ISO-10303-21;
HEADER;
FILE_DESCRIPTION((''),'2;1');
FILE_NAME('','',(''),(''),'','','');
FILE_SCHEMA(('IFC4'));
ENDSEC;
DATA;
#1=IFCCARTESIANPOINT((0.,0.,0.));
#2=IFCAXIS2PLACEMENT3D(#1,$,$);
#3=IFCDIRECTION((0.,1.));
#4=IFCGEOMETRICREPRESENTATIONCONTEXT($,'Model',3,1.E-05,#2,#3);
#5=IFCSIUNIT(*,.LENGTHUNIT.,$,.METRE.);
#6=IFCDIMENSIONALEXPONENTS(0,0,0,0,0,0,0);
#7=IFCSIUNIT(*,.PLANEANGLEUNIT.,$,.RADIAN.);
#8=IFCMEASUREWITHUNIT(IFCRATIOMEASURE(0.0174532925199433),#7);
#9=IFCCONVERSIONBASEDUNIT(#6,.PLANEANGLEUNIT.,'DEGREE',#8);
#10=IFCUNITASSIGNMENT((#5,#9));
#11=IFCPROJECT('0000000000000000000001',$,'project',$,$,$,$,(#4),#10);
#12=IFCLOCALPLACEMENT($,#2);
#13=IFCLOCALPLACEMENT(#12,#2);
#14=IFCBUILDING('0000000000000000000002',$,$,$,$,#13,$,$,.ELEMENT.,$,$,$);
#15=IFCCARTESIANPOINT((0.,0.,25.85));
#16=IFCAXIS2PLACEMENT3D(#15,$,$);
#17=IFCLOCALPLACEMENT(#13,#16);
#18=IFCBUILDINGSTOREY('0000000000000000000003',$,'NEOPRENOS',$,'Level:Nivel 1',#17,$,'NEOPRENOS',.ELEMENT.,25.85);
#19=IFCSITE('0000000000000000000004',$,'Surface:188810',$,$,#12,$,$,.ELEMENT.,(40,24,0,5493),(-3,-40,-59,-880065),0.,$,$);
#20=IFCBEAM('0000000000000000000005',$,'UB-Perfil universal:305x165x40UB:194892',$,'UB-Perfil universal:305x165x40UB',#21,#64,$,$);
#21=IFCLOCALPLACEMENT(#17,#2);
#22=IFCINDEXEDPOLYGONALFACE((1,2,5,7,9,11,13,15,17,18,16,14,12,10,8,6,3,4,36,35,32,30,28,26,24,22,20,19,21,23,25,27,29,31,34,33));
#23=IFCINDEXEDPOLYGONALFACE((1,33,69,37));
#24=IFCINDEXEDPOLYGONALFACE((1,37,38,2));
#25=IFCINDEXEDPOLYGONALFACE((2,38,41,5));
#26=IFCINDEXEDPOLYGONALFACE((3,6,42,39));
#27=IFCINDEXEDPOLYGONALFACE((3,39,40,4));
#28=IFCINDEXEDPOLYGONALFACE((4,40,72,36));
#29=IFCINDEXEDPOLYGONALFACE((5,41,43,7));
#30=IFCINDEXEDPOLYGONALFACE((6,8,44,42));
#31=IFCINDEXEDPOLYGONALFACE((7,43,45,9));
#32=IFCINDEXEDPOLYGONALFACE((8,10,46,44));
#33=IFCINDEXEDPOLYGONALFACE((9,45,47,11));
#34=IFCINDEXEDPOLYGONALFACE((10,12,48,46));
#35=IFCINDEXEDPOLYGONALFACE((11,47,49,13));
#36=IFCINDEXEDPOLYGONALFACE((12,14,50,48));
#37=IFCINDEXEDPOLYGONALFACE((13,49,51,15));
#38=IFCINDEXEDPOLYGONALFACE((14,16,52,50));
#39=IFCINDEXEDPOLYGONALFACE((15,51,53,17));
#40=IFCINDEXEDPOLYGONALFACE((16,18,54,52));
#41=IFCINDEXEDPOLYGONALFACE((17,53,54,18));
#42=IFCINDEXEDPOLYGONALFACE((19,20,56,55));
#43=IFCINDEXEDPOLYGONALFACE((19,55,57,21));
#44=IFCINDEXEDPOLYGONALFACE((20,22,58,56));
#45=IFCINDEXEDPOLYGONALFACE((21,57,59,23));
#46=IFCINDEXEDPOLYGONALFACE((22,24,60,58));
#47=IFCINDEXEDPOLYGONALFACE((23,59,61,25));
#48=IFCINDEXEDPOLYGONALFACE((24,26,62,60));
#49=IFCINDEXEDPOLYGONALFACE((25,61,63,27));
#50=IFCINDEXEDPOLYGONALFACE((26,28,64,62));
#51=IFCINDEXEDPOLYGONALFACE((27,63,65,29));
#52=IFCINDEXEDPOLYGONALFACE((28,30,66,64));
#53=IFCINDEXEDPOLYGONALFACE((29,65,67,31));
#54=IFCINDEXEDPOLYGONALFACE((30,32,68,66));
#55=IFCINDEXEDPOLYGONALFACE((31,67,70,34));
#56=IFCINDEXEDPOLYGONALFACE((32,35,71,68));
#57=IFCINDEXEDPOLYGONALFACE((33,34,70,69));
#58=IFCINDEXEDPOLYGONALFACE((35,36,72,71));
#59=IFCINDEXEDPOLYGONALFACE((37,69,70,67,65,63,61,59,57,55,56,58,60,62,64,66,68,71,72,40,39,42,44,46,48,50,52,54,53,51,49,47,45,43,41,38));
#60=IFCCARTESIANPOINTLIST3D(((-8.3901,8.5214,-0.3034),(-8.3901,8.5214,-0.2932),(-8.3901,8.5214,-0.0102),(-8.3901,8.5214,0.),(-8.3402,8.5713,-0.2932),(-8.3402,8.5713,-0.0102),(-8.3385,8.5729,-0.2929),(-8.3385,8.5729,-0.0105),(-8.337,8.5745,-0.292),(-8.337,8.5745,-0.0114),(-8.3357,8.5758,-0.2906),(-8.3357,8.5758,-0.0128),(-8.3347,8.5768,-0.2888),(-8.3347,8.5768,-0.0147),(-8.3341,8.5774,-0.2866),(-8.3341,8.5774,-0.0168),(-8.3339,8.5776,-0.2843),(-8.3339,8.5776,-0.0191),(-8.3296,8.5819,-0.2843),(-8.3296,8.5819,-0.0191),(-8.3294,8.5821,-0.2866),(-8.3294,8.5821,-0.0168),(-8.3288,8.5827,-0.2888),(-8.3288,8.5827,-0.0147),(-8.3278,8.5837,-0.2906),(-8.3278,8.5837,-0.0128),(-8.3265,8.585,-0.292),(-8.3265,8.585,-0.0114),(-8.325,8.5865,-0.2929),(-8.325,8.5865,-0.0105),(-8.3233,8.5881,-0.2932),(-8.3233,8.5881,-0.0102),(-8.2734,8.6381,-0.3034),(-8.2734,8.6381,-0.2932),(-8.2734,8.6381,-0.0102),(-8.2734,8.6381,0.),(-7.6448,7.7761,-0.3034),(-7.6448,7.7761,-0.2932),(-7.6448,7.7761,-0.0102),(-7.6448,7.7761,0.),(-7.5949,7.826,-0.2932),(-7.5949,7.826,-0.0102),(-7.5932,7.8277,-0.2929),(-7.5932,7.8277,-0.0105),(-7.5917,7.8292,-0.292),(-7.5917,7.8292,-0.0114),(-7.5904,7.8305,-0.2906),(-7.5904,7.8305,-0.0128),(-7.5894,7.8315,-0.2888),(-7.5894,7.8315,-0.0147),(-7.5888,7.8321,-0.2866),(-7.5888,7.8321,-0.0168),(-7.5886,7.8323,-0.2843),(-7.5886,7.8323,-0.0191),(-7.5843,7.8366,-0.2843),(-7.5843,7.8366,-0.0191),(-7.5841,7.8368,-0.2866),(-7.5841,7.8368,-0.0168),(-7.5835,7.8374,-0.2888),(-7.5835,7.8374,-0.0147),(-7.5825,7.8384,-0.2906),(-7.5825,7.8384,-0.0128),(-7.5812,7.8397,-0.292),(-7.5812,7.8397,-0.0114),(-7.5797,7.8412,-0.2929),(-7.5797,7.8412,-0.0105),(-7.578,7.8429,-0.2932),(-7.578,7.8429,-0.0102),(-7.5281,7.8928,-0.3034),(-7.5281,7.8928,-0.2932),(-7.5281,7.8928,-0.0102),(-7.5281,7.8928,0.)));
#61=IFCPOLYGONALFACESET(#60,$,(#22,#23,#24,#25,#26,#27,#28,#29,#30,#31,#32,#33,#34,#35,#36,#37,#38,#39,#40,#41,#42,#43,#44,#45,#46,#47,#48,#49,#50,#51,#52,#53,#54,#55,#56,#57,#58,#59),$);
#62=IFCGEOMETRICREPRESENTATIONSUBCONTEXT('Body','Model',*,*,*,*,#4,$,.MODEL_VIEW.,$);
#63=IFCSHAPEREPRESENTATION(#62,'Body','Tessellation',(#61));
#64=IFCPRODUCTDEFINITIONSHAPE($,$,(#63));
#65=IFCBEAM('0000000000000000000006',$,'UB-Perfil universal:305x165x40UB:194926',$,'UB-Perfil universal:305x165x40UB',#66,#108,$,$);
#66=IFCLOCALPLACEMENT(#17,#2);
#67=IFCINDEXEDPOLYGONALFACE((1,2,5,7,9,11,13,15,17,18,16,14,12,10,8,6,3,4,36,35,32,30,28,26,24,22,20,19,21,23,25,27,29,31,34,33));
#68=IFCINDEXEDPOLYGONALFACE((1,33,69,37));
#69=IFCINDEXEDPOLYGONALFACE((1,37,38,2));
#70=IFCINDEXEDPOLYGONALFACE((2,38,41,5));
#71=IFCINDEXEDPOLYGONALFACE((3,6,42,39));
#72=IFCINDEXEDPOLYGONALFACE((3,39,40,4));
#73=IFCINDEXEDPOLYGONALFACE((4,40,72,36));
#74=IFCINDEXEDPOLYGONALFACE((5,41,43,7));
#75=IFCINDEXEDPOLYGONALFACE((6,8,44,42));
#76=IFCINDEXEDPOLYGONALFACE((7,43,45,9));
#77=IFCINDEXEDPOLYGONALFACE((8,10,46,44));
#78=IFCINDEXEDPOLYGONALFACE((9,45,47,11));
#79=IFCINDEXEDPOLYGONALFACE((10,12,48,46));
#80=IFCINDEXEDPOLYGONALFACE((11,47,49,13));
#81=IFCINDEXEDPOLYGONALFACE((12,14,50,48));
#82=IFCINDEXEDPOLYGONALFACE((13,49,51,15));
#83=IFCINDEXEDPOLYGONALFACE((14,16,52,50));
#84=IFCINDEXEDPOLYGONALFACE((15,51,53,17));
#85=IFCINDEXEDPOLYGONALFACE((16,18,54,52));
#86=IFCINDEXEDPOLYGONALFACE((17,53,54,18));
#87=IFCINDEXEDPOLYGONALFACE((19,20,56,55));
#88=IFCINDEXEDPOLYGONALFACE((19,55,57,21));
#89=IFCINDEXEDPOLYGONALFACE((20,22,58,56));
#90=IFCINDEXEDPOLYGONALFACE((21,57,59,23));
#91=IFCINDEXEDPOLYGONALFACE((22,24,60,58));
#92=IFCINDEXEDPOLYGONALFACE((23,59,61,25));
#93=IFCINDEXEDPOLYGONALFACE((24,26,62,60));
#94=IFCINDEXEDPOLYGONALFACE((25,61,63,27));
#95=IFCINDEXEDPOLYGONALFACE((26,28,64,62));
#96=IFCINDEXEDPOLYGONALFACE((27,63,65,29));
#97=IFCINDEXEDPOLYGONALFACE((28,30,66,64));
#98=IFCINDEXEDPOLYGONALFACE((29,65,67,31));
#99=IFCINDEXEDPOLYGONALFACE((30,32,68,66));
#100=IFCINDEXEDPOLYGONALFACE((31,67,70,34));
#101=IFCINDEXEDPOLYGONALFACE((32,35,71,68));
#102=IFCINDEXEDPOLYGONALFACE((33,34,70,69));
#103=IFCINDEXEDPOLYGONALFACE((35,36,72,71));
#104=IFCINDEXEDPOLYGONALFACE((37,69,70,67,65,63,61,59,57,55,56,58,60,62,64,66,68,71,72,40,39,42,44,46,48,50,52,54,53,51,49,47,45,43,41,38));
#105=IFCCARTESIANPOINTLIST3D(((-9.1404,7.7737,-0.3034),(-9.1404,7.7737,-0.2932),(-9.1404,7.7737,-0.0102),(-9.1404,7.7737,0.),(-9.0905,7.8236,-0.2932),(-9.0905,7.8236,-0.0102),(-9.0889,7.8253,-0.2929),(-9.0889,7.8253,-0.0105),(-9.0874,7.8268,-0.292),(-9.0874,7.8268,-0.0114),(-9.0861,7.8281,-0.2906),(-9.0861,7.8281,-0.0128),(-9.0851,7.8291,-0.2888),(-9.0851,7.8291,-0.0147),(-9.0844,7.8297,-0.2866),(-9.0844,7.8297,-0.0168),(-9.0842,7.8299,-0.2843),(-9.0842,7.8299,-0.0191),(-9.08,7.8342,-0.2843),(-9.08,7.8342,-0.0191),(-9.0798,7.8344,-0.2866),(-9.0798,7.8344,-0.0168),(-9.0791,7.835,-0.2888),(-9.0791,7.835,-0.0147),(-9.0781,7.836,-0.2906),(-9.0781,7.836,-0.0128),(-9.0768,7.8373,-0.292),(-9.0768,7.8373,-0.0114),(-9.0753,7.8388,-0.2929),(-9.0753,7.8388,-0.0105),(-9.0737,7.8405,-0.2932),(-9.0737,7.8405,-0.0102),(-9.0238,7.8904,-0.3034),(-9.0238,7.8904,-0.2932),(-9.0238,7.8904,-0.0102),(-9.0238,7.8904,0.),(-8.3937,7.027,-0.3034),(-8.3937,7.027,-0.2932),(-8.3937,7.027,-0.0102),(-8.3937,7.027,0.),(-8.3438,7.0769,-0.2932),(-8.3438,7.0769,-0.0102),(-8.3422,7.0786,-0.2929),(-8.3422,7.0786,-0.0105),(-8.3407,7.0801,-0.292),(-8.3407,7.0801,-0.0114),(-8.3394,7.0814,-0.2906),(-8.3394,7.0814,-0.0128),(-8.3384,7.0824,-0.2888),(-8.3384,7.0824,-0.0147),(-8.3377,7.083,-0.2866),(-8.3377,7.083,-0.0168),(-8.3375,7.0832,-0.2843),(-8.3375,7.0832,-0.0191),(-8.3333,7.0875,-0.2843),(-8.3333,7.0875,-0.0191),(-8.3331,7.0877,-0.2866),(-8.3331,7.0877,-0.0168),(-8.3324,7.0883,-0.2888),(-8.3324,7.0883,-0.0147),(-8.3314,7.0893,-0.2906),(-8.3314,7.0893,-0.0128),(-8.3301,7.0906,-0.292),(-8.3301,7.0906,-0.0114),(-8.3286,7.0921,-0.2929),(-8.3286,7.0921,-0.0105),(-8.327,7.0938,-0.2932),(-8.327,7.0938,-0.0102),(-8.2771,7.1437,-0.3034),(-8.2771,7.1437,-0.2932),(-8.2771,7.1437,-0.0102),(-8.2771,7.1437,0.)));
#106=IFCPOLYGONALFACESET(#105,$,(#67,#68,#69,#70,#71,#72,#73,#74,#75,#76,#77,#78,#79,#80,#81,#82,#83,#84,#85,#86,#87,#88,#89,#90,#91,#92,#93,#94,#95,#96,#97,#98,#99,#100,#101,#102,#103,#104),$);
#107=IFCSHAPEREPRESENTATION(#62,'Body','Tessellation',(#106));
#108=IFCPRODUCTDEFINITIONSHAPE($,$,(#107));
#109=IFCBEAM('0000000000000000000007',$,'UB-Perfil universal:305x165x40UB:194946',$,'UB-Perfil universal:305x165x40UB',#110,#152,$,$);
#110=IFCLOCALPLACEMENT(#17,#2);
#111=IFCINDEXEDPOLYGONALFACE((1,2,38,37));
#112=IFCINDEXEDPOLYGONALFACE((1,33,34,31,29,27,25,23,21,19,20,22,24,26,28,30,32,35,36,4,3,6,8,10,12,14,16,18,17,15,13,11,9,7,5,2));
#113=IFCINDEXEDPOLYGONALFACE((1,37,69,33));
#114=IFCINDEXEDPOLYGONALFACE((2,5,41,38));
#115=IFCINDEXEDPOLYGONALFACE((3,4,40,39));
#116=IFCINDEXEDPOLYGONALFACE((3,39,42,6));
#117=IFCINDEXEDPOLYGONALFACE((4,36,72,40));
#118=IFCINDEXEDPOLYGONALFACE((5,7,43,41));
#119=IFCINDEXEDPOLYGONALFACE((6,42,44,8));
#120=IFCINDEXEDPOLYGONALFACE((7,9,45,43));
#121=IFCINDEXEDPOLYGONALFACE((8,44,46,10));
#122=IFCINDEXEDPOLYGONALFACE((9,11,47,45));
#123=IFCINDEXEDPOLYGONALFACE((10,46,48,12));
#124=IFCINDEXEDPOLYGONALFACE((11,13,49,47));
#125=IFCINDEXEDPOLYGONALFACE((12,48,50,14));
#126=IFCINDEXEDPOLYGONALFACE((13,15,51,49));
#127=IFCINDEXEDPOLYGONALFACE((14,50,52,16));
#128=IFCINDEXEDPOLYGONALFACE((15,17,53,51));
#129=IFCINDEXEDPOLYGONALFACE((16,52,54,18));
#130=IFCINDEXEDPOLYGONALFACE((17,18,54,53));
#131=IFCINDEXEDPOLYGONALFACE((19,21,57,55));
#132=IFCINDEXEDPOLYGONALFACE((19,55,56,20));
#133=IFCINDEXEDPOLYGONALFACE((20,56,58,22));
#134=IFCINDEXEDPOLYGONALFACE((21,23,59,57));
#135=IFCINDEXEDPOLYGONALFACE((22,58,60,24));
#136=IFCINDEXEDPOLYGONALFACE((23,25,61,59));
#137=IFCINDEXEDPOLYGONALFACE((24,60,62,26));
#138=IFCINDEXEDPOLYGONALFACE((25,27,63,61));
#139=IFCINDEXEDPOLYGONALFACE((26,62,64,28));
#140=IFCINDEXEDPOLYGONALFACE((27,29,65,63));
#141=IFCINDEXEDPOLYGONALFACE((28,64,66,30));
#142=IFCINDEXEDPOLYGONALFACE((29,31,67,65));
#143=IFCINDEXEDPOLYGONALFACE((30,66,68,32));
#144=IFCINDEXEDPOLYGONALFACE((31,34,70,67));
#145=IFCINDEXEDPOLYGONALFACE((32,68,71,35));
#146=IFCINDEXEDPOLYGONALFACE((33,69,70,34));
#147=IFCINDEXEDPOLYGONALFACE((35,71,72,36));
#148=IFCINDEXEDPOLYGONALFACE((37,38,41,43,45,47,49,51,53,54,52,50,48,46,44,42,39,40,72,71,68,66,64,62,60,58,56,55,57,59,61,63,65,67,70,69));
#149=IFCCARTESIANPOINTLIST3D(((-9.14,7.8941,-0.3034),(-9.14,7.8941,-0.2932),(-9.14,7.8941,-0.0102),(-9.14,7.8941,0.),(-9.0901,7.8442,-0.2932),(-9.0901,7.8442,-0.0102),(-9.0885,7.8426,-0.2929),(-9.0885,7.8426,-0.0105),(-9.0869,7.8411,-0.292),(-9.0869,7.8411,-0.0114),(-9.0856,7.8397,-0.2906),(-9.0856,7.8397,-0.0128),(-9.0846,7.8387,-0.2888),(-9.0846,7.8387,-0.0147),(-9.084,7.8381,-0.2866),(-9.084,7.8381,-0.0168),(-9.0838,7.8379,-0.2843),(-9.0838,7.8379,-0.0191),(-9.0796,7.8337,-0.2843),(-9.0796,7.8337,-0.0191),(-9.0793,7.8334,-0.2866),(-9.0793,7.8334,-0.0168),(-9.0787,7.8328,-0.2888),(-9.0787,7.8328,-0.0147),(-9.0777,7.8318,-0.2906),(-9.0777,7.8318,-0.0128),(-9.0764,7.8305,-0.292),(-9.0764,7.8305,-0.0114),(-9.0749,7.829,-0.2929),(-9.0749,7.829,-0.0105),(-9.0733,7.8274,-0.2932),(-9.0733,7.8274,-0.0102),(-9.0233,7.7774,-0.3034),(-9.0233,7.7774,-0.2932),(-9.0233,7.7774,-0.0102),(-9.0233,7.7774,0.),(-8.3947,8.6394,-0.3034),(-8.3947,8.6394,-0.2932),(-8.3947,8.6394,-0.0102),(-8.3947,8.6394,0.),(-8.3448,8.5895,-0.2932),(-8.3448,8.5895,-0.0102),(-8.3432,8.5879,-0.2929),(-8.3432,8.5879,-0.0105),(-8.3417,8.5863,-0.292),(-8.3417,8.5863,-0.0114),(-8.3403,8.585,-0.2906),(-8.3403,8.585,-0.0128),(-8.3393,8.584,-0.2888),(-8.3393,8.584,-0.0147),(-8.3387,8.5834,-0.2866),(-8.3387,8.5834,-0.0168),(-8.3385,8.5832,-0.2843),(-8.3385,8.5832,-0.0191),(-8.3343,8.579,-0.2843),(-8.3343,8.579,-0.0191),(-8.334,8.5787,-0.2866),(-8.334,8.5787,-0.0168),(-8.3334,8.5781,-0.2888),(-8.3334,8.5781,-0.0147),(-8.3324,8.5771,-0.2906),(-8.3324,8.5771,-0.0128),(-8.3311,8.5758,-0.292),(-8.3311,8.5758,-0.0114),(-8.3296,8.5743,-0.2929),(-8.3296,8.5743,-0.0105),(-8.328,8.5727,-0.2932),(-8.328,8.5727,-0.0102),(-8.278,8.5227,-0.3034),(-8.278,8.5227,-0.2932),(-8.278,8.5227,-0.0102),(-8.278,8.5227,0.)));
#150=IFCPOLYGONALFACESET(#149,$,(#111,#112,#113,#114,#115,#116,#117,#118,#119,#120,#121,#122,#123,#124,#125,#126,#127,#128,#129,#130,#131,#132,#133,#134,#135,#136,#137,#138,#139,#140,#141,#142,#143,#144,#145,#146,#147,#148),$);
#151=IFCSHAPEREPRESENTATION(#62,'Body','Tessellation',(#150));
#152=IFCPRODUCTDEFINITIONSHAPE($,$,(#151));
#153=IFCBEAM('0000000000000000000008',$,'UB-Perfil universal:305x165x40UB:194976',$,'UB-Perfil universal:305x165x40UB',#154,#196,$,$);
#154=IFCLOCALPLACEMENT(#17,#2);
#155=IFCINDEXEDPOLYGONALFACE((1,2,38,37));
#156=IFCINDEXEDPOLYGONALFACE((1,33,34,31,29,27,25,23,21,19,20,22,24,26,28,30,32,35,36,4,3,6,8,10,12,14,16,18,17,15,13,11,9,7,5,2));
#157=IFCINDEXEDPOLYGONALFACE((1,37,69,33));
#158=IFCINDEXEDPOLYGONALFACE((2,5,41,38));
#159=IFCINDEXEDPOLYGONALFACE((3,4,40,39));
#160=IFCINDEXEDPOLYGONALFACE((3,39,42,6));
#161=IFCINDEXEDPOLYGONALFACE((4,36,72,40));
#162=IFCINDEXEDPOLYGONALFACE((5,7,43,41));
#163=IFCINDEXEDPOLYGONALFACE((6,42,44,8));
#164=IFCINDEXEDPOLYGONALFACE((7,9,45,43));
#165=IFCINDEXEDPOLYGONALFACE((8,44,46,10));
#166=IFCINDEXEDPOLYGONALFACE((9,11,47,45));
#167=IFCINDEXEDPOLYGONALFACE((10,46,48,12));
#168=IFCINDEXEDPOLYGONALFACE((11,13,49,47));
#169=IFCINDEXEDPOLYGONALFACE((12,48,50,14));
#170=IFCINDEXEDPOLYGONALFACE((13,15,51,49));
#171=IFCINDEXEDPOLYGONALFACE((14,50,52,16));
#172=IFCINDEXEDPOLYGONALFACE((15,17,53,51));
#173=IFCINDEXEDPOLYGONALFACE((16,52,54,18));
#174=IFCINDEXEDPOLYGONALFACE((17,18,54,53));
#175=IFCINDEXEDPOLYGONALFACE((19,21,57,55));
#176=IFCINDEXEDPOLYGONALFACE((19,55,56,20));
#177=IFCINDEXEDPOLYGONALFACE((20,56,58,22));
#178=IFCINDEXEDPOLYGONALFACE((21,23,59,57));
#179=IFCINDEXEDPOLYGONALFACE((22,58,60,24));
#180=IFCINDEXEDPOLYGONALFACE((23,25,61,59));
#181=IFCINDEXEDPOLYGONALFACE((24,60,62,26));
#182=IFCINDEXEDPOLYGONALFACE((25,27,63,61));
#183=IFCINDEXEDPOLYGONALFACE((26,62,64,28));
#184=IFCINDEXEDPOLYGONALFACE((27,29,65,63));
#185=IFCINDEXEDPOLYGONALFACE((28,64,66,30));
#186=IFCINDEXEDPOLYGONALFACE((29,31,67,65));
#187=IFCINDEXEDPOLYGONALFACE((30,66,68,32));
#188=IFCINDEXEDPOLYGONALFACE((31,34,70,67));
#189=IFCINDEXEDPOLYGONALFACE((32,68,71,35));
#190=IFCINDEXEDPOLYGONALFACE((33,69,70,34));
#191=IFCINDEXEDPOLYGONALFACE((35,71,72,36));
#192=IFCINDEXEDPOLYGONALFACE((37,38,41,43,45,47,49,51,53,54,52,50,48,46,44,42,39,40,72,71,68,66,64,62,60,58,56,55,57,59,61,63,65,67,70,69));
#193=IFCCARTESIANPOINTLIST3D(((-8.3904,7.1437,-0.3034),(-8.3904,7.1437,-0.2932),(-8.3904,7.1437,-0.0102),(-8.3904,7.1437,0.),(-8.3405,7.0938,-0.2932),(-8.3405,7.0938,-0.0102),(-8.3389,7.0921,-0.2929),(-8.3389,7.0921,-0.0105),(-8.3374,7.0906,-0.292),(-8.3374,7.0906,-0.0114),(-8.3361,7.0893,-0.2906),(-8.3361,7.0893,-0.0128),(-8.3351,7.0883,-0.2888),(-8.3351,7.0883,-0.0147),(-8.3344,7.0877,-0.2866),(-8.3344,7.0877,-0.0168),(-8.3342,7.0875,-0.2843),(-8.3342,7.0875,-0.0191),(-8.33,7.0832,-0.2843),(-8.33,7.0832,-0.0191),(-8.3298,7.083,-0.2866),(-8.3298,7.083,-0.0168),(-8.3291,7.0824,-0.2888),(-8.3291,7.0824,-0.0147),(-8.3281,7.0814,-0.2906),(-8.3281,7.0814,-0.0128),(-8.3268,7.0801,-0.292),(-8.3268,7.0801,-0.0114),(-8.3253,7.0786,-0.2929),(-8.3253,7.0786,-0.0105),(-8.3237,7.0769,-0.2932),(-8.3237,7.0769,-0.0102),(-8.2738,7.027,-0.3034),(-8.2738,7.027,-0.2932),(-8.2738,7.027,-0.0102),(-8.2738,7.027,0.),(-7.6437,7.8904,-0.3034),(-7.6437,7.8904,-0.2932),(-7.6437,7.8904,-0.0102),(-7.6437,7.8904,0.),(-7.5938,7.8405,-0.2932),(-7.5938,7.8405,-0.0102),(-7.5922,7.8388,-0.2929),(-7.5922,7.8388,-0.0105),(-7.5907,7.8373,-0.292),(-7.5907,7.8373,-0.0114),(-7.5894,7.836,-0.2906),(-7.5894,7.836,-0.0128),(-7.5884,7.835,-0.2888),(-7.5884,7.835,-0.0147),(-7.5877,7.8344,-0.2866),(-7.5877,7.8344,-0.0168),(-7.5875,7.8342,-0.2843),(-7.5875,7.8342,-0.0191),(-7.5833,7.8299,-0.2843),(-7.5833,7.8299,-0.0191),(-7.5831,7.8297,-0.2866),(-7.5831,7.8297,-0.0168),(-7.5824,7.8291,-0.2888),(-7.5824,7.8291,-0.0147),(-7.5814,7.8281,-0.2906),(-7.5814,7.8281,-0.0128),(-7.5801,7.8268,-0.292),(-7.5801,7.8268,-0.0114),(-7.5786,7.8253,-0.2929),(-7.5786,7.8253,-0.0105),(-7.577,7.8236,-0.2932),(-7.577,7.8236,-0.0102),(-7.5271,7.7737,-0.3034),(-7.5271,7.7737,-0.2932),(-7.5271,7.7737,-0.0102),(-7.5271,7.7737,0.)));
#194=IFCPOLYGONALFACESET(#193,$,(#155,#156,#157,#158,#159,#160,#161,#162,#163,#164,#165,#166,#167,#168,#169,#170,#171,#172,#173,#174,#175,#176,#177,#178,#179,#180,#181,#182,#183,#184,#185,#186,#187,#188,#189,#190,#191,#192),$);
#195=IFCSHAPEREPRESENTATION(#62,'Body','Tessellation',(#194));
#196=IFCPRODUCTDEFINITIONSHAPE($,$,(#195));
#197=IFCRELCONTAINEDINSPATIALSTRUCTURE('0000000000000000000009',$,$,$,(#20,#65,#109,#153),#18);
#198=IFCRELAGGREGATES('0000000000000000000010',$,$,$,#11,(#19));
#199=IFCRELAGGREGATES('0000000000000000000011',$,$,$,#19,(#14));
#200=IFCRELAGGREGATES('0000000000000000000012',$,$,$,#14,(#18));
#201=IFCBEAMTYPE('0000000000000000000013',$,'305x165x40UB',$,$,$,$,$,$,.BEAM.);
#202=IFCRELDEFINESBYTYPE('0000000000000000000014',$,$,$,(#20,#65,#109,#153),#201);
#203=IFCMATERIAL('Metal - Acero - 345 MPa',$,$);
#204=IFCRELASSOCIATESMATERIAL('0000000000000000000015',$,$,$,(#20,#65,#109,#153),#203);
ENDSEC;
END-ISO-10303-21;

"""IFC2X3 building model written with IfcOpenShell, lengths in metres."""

from ifc_helpers import new_model, entity, si_unit, converted_unit, direction, frame, frame_2d, origin, place, context, subcontext, project, spatial, i_section, extrude, material, type_object, element, save


model = new_model("IFC2X3")

# Units and contexts
model_context = context("Model", 3, precision=1e-05, world=origin(), true_north=direction((0.0, 1.0)))
body_context = subcontext(model_context, "Body", "Model", "MODEL_VIEW")
ifc_project = project(units=[si_unit("LENGTHUNIT", "METRE"), converted_unit("PLANEANGLEUNIT", "DEGREE", entity("IfcRatioMeasure", 0.0174532925199433), si_unit("PLANEANGLEUNIT", "RADIAN"), dimensions=[0, 0, 0, 0, 0, 0, 0])], contexts=[model_context])

# Site, building, storey
site_placement = place(None, origin())
site = spatial("IfcSite", under=ifc_project, at=site_placement, Name="Surface:188810", CompositionType="ELEMENT", RefLatitude=(40, 24, 0, 5493), RefLongitude=(-3, -40, -59, -880065), RefElevation=0.0)
building_placement = place(site_placement, origin())
building = spatial("IfcBuilding", under=site, at=building_placement, CompositionType="ELEMENT")
storey_placement = place(building_placement, frame((0.0, 0.0, 25.85)))
storey = spatial("IfcBuildingStorey", under=building, at=storey_placement, Name="NEOPRENOS", ObjectType="Level:Nivel 1", LongName="NEOPRENOS", CompositionType="ELEMENT", Elevation=25.85)

# Beams
ifc_material_1 = material(Name="Metal - Acero - 345 MPa")
beam_type = type_object("IfcBeamType", Name="305x165x40UB", PredefinedType="BEAM")
beam_1_placement = place(storey_placement, frame((-8.3337, 8.5817, 0.0), z_axis=(0.0, 0.0, 1.0), x_axis=(0.707107, -0.707107, 0.0)))
element("IfcBeam", 1, at=beam_1_placement, inside=storey, type_object=beam_type, material=ifc_material_1, Name="UB-Perfil universal:305x165x40UB:194892", ObjectType="UB-Perfil universal:305x165x40UB", context=body_context, shape_type="SweptSolid", body=[
    extrude(i_section(OverallWidth=0.165, OverallDepth=0.3034, WebThickness=0.006, FlangeThickness=0.0102, FilletRadius=0.0089, at=frame_2d((0.0, 0.0), x_axis=(0.0, 1.0))), frame((0.0028, 0.0, -0.1517), z_axis=(1.0, 0.0, 0.0), x_axis=(0.0, 0.0, -1.0)), (0.0, 0.0, 1.0), 1.054),
])
beam_2_placement = place(storey_placement, frame((-8.3337, 7.0837, 0.0), z_axis=(0.0, 0.0, 1.0), x_axis=(-0.707107, 0.707107, 0.0)))
element("IfcBeam", 2, at=beam_2_placement, inside=storey, type_object=beam_type, material=ifc_material_1, Name="UB-Perfil universal:305x165x40UB:194926", ObjectType="UB-Perfil universal:305x165x40UB", context=body_context, shape_type="SweptSolid", body=[
    extrude(i_section(OverallWidth=0.165, OverallDepth=0.3034, WebThickness=0.006, FlangeThickness=0.0102, FilletRadius=0.0089, at=frame_2d((0.0, 0.0), x_axis=(0.0, 1.0))), frame((0.0023, 0.0, -0.1517), z_axis=(1.0, 0.0, 0.0), x_axis=(0.0, 0.0, -1.0)), (0.0, 0.0, 1.0), 1.056),
])
beam_3_placement = place(storey_placement, frame((-9.0837, 7.8337, 0.0), z_axis=(0.0, 0.0, 1.0), x_axis=(0.707107, 0.707107, 0.0)))
element("IfcBeam", 3, at=beam_3_placement, inside=storey, type_object=beam_type, material=ifc_material_1, Name="UB-Perfil universal:305x165x40UB:194946", ObjectType="UB-Perfil universal:305x165x40UB", context=body_context, shape_type="SweptSolid", body=[
    extrude(i_section(OverallWidth=0.165, OverallDepth=0.3034, WebThickness=0.006, FlangeThickness=0.0102, FilletRadius=0.0089, at=frame_2d((0.0, 0.0), x_axis=(0.0, 1.0))), frame((0.0029, 0.0, -0.1517), z_axis=(1.0, 0.0, 0.0), x_axis=(0.0, 0.0, -1.0)), (0.0, 0.0, 1.0), 1.054),
])
beam_4_placement = place(storey_placement, frame((-7.5837, 7.8337, 0.0), z_axis=(0.0, 0.0, 1.0), x_axis=(-0.707107, -0.707107, 0.0)))
element("IfcBeam", 4, at=beam_4_placement, inside=storey, type_object=beam_type, material=ifc_material_1, Name="UB-Perfil universal:305x165x40UB:194976", ObjectType="UB-Perfil universal:305x165x40UB", context=body_context, shape_type="SweptSolid", body=[
    extrude(i_section(OverallWidth=0.165, OverallDepth=0.3034, WebThickness=0.006, FlangeThickness=0.0102, FilletRadius=0.0089, at=frame_2d((0.0, 0.0), x_axis=(0.0, 1.0))), frame((0.0023, 0.0, -0.1517), z_axis=(1.0, 0.0, 0.0), x_axis=(0.0, 0.0, -1.0)), (0.0, 0.0, 1.0), 1.056),
])

save(model, "model.ifc")
